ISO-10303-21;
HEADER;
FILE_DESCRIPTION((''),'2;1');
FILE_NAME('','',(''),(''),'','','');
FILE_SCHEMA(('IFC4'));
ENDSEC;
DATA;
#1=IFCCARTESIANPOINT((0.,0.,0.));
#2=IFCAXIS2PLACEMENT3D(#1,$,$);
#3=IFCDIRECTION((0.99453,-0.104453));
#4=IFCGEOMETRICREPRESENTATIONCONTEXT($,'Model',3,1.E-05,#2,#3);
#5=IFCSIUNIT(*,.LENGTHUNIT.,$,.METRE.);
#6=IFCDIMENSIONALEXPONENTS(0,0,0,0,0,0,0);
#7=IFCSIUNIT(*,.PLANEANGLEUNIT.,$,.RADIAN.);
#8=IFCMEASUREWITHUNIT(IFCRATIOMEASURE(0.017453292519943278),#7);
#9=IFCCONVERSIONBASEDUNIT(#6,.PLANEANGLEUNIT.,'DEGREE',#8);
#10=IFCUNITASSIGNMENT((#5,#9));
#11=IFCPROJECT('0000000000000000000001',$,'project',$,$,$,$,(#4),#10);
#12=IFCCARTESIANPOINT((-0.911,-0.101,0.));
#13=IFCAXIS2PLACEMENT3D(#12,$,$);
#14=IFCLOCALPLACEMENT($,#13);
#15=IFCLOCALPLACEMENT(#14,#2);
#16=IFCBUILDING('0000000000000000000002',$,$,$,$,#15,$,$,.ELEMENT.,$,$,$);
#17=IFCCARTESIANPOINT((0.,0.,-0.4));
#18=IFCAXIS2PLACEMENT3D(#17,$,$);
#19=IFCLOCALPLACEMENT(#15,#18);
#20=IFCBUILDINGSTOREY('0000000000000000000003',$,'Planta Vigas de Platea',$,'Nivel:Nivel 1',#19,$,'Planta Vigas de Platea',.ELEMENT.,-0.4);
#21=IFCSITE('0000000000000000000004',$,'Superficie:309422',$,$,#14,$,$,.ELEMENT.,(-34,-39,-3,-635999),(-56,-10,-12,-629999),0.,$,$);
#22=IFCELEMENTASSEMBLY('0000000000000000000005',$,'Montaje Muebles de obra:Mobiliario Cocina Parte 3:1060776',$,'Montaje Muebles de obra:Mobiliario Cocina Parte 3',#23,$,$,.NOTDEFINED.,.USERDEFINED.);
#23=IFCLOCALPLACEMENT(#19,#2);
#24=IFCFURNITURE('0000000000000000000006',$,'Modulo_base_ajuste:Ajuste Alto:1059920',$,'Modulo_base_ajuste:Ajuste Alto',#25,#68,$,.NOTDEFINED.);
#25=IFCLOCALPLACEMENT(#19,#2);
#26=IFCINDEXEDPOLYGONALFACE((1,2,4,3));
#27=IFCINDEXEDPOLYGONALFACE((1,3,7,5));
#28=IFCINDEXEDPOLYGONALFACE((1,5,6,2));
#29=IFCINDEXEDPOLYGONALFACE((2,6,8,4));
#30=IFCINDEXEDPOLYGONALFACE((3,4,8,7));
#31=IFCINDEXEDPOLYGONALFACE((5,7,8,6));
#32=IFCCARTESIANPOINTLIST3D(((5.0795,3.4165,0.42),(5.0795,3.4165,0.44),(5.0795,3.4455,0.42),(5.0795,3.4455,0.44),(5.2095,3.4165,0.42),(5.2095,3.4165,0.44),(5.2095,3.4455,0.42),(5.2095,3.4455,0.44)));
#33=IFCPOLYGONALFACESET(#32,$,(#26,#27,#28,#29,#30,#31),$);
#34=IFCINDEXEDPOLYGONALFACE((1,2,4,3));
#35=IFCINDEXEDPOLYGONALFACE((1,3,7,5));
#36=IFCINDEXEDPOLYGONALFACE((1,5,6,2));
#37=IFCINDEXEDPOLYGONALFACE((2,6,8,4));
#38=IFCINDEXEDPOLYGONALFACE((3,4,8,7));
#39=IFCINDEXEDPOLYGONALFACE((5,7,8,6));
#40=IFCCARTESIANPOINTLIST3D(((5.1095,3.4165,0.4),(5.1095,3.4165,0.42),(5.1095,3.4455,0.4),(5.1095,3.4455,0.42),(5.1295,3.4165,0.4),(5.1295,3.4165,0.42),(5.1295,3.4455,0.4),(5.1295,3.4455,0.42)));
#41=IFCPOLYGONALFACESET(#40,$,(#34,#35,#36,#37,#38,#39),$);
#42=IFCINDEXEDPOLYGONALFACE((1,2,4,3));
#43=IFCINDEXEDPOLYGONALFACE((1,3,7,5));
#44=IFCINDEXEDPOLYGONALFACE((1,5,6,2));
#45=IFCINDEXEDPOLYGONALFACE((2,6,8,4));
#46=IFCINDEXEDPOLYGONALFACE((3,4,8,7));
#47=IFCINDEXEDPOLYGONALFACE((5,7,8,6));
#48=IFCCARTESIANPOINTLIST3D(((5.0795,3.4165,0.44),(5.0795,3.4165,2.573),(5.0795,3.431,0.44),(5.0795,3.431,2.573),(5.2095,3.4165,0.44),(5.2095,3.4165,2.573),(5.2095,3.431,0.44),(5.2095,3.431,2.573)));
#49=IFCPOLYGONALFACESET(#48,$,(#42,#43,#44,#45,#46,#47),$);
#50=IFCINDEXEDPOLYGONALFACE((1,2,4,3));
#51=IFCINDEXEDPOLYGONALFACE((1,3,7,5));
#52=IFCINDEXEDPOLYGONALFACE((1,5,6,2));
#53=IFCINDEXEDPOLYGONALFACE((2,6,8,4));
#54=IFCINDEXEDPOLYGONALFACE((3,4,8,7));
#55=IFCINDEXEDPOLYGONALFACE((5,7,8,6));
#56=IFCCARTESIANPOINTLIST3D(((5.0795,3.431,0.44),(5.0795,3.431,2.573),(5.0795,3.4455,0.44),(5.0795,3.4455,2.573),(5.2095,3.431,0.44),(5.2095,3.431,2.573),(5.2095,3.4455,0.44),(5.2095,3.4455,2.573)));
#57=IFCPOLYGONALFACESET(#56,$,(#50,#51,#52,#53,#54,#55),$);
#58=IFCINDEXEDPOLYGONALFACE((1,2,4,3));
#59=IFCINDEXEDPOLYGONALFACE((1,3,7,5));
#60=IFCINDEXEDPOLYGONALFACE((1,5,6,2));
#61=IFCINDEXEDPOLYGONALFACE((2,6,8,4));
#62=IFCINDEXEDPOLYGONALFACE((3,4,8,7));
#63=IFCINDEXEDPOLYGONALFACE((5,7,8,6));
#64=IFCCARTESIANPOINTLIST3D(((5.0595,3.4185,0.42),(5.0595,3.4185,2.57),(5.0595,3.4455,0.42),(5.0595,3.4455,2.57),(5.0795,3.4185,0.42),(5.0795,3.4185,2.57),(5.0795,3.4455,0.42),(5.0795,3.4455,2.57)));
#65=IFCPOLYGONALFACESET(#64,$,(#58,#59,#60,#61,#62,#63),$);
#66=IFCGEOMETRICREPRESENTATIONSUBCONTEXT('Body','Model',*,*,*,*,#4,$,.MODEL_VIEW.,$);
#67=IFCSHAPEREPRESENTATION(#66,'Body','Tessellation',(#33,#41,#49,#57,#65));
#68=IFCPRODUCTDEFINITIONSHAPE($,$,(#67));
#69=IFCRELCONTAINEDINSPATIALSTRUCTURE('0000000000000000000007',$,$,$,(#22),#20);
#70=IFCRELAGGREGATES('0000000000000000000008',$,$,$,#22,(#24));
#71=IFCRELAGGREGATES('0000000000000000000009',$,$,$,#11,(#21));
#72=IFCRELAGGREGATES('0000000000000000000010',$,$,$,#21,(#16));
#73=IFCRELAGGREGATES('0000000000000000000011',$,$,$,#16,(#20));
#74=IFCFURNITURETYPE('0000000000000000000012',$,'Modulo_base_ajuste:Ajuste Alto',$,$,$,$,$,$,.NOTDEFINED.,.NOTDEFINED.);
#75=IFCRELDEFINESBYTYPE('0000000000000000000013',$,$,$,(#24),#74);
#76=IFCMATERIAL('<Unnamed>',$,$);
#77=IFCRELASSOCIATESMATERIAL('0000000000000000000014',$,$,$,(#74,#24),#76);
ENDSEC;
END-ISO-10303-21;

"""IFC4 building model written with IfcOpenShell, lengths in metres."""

from ifc_helpers import new_model, entity, si_unit, converted_unit, direction, frame, frame_2d, origin, origin_2d_with_axis, place, context, subcontext, project, spatial, rectangle, extrude, source, transform, mapped, material, type_object, type_shapes, element, aggregate, save


model = new_model("IFC4")

# Units and contexts
model_context = context("Model", 3, precision=1e-05, world=origin(), true_north=direction((0.99453, -0.104453)))
body_context = subcontext(model_context, "Body", "Model", "MODEL_VIEW")
ifc_project = project(units=[si_unit("LENGTHUNIT", "METRE"), converted_unit("PLANEANGLEUNIT", "DEGREE", entity("IfcRatioMeasure", 0.017453292519943278), si_unit("PLANEANGLEUNIT", "RADIAN"), dimensions=[0, 0, 0, 0, 0, 0, 0])], contexts=[model_context])

# Site, building, storey
site_placement = place(None, frame((-0.911, -0.101, 0.0)))
site = spatial("IfcSite", under=ifc_project, at=site_placement, Name="Superficie:309422", CompositionType="ELEMENT", RefLatitude=(-34, -39, -3, -635999), RefLongitude=(-56, -10, -12, -629999), RefElevation=0.0)
building_placement = place(site_placement, origin())
building = spatial("IfcBuilding", under=site, at=building_placement, CompositionType="ELEMENT")
storey_placement = place(building_placement, frame((0.0, 0.0, -0.4)))
storey = spatial("IfcBuildingStorey", under=building, at=storey_placement, Name="Planta Vigas de Platea", ObjectType="Nivel:Nivel 1", LongName="Planta Vigas de Platea", CompositionType="ELEMENT", Elevation=-0.4)

# Element assembly
ifc_material_1 = material(Name="<Unnamed>")
assembly_1_placement = place(storey_placement, origin())
assembly_1 = element("IfcElementAssembly", 1, at=assembly_1_placement, inside=storey, Name="Montaje Muebles de obra:Mobiliario Cocina Parte 3:1060776", ObjectType="Montaje Muebles de obra:Mobiliario Cocina Parte 3", AssemblyPlace="NOTDEFINED", PredefinedType="USERDEFINED")

# Furniture
furniture_type_1 = type_object("IfcFurnitureType", Name="Modulo_base_ajuste:Ajuste Alto", AssemblyPlace="NOTDEFINED", PredefinedType="NOTDEFINED", material=ifc_material_1)
shared_shape_1 = source(origin(), body_context, "Body", "SweptSolid", [
    extrude(rectangle(XDim=0.13, YDim=0.029, at=origin_2d_with_axis()), frame((0.085, 0.0145, 0.02), z_axis=(0.0, 0.0, 1.0), x_axis=(-1.0, 0.0, 0.0)), (0.0, 0.0, 1.0), 0.02),
    extrude(rectangle(XDim=0.029, YDim=0.02, at=frame_2d((0.0, 0.0), x_axis=(1.0, 0.0))), frame((0.06, 0.0145, 0.0), z_axis=(0.0, 0.0, 1.0), x_axis=(0.0, 1.0, 0.0)), (0.0, 0.0, 1.0), 0.02),
    extrude(rectangle(XDim=0.13, YDim=0.0145, at=frame_2d((0.0, 0.0), x_axis=(1.0, 0.0))), frame((0.085, 0.0072, 0.04), z_axis=(0.0, 0.0, 1.0), x_axis=(-1.0, 0.0, 0.0)), (0.0, 0.0, 1.0), 2.133),
    extrude(rectangle(XDim=0.13, YDim=0.0145, at=frame_2d((0.0, 0.0), x_axis=(1.0, 0.0))), frame((0.085, 0.0218, 0.04)), (0.0, 0.0, 1.0), 2.133),
    extrude(rectangle(XDim=0.027, YDim=0.02, at=origin_2d_with_axis()), frame((0.01, 0.0155, 0.02), z_axis=(0.0, 0.0, 1.0), x_axis=(0.0, -1.0, 0.0)), (0.0, 0.0, 1.0), 2.15),
])
type_shapes(furniture_type_1, [shared_shape_1])
furniture_1_placement = place(assembly_1_placement, frame((5.0595, 3.4165, 0.4)))
furniture_1 = element("IfcFurniture", 2, at=furniture_1_placement, type_object=furniture_type_1, material=ifc_material_1, Name="Modulo_base_ajuste:Ajuste Alto:1059920", ObjectType="Modulo_base_ajuste:Ajuste Alto", PredefinedType="NOTDEFINED", context=body_context, shape_type="MappedRepresentation", body=[
    mapped(shared_shape_1, transform((0.0, 0.0, 0.0), scale=1.0)),
])
aggregate(assembly_1, [furniture_1])

save(model, "model.ifc")
